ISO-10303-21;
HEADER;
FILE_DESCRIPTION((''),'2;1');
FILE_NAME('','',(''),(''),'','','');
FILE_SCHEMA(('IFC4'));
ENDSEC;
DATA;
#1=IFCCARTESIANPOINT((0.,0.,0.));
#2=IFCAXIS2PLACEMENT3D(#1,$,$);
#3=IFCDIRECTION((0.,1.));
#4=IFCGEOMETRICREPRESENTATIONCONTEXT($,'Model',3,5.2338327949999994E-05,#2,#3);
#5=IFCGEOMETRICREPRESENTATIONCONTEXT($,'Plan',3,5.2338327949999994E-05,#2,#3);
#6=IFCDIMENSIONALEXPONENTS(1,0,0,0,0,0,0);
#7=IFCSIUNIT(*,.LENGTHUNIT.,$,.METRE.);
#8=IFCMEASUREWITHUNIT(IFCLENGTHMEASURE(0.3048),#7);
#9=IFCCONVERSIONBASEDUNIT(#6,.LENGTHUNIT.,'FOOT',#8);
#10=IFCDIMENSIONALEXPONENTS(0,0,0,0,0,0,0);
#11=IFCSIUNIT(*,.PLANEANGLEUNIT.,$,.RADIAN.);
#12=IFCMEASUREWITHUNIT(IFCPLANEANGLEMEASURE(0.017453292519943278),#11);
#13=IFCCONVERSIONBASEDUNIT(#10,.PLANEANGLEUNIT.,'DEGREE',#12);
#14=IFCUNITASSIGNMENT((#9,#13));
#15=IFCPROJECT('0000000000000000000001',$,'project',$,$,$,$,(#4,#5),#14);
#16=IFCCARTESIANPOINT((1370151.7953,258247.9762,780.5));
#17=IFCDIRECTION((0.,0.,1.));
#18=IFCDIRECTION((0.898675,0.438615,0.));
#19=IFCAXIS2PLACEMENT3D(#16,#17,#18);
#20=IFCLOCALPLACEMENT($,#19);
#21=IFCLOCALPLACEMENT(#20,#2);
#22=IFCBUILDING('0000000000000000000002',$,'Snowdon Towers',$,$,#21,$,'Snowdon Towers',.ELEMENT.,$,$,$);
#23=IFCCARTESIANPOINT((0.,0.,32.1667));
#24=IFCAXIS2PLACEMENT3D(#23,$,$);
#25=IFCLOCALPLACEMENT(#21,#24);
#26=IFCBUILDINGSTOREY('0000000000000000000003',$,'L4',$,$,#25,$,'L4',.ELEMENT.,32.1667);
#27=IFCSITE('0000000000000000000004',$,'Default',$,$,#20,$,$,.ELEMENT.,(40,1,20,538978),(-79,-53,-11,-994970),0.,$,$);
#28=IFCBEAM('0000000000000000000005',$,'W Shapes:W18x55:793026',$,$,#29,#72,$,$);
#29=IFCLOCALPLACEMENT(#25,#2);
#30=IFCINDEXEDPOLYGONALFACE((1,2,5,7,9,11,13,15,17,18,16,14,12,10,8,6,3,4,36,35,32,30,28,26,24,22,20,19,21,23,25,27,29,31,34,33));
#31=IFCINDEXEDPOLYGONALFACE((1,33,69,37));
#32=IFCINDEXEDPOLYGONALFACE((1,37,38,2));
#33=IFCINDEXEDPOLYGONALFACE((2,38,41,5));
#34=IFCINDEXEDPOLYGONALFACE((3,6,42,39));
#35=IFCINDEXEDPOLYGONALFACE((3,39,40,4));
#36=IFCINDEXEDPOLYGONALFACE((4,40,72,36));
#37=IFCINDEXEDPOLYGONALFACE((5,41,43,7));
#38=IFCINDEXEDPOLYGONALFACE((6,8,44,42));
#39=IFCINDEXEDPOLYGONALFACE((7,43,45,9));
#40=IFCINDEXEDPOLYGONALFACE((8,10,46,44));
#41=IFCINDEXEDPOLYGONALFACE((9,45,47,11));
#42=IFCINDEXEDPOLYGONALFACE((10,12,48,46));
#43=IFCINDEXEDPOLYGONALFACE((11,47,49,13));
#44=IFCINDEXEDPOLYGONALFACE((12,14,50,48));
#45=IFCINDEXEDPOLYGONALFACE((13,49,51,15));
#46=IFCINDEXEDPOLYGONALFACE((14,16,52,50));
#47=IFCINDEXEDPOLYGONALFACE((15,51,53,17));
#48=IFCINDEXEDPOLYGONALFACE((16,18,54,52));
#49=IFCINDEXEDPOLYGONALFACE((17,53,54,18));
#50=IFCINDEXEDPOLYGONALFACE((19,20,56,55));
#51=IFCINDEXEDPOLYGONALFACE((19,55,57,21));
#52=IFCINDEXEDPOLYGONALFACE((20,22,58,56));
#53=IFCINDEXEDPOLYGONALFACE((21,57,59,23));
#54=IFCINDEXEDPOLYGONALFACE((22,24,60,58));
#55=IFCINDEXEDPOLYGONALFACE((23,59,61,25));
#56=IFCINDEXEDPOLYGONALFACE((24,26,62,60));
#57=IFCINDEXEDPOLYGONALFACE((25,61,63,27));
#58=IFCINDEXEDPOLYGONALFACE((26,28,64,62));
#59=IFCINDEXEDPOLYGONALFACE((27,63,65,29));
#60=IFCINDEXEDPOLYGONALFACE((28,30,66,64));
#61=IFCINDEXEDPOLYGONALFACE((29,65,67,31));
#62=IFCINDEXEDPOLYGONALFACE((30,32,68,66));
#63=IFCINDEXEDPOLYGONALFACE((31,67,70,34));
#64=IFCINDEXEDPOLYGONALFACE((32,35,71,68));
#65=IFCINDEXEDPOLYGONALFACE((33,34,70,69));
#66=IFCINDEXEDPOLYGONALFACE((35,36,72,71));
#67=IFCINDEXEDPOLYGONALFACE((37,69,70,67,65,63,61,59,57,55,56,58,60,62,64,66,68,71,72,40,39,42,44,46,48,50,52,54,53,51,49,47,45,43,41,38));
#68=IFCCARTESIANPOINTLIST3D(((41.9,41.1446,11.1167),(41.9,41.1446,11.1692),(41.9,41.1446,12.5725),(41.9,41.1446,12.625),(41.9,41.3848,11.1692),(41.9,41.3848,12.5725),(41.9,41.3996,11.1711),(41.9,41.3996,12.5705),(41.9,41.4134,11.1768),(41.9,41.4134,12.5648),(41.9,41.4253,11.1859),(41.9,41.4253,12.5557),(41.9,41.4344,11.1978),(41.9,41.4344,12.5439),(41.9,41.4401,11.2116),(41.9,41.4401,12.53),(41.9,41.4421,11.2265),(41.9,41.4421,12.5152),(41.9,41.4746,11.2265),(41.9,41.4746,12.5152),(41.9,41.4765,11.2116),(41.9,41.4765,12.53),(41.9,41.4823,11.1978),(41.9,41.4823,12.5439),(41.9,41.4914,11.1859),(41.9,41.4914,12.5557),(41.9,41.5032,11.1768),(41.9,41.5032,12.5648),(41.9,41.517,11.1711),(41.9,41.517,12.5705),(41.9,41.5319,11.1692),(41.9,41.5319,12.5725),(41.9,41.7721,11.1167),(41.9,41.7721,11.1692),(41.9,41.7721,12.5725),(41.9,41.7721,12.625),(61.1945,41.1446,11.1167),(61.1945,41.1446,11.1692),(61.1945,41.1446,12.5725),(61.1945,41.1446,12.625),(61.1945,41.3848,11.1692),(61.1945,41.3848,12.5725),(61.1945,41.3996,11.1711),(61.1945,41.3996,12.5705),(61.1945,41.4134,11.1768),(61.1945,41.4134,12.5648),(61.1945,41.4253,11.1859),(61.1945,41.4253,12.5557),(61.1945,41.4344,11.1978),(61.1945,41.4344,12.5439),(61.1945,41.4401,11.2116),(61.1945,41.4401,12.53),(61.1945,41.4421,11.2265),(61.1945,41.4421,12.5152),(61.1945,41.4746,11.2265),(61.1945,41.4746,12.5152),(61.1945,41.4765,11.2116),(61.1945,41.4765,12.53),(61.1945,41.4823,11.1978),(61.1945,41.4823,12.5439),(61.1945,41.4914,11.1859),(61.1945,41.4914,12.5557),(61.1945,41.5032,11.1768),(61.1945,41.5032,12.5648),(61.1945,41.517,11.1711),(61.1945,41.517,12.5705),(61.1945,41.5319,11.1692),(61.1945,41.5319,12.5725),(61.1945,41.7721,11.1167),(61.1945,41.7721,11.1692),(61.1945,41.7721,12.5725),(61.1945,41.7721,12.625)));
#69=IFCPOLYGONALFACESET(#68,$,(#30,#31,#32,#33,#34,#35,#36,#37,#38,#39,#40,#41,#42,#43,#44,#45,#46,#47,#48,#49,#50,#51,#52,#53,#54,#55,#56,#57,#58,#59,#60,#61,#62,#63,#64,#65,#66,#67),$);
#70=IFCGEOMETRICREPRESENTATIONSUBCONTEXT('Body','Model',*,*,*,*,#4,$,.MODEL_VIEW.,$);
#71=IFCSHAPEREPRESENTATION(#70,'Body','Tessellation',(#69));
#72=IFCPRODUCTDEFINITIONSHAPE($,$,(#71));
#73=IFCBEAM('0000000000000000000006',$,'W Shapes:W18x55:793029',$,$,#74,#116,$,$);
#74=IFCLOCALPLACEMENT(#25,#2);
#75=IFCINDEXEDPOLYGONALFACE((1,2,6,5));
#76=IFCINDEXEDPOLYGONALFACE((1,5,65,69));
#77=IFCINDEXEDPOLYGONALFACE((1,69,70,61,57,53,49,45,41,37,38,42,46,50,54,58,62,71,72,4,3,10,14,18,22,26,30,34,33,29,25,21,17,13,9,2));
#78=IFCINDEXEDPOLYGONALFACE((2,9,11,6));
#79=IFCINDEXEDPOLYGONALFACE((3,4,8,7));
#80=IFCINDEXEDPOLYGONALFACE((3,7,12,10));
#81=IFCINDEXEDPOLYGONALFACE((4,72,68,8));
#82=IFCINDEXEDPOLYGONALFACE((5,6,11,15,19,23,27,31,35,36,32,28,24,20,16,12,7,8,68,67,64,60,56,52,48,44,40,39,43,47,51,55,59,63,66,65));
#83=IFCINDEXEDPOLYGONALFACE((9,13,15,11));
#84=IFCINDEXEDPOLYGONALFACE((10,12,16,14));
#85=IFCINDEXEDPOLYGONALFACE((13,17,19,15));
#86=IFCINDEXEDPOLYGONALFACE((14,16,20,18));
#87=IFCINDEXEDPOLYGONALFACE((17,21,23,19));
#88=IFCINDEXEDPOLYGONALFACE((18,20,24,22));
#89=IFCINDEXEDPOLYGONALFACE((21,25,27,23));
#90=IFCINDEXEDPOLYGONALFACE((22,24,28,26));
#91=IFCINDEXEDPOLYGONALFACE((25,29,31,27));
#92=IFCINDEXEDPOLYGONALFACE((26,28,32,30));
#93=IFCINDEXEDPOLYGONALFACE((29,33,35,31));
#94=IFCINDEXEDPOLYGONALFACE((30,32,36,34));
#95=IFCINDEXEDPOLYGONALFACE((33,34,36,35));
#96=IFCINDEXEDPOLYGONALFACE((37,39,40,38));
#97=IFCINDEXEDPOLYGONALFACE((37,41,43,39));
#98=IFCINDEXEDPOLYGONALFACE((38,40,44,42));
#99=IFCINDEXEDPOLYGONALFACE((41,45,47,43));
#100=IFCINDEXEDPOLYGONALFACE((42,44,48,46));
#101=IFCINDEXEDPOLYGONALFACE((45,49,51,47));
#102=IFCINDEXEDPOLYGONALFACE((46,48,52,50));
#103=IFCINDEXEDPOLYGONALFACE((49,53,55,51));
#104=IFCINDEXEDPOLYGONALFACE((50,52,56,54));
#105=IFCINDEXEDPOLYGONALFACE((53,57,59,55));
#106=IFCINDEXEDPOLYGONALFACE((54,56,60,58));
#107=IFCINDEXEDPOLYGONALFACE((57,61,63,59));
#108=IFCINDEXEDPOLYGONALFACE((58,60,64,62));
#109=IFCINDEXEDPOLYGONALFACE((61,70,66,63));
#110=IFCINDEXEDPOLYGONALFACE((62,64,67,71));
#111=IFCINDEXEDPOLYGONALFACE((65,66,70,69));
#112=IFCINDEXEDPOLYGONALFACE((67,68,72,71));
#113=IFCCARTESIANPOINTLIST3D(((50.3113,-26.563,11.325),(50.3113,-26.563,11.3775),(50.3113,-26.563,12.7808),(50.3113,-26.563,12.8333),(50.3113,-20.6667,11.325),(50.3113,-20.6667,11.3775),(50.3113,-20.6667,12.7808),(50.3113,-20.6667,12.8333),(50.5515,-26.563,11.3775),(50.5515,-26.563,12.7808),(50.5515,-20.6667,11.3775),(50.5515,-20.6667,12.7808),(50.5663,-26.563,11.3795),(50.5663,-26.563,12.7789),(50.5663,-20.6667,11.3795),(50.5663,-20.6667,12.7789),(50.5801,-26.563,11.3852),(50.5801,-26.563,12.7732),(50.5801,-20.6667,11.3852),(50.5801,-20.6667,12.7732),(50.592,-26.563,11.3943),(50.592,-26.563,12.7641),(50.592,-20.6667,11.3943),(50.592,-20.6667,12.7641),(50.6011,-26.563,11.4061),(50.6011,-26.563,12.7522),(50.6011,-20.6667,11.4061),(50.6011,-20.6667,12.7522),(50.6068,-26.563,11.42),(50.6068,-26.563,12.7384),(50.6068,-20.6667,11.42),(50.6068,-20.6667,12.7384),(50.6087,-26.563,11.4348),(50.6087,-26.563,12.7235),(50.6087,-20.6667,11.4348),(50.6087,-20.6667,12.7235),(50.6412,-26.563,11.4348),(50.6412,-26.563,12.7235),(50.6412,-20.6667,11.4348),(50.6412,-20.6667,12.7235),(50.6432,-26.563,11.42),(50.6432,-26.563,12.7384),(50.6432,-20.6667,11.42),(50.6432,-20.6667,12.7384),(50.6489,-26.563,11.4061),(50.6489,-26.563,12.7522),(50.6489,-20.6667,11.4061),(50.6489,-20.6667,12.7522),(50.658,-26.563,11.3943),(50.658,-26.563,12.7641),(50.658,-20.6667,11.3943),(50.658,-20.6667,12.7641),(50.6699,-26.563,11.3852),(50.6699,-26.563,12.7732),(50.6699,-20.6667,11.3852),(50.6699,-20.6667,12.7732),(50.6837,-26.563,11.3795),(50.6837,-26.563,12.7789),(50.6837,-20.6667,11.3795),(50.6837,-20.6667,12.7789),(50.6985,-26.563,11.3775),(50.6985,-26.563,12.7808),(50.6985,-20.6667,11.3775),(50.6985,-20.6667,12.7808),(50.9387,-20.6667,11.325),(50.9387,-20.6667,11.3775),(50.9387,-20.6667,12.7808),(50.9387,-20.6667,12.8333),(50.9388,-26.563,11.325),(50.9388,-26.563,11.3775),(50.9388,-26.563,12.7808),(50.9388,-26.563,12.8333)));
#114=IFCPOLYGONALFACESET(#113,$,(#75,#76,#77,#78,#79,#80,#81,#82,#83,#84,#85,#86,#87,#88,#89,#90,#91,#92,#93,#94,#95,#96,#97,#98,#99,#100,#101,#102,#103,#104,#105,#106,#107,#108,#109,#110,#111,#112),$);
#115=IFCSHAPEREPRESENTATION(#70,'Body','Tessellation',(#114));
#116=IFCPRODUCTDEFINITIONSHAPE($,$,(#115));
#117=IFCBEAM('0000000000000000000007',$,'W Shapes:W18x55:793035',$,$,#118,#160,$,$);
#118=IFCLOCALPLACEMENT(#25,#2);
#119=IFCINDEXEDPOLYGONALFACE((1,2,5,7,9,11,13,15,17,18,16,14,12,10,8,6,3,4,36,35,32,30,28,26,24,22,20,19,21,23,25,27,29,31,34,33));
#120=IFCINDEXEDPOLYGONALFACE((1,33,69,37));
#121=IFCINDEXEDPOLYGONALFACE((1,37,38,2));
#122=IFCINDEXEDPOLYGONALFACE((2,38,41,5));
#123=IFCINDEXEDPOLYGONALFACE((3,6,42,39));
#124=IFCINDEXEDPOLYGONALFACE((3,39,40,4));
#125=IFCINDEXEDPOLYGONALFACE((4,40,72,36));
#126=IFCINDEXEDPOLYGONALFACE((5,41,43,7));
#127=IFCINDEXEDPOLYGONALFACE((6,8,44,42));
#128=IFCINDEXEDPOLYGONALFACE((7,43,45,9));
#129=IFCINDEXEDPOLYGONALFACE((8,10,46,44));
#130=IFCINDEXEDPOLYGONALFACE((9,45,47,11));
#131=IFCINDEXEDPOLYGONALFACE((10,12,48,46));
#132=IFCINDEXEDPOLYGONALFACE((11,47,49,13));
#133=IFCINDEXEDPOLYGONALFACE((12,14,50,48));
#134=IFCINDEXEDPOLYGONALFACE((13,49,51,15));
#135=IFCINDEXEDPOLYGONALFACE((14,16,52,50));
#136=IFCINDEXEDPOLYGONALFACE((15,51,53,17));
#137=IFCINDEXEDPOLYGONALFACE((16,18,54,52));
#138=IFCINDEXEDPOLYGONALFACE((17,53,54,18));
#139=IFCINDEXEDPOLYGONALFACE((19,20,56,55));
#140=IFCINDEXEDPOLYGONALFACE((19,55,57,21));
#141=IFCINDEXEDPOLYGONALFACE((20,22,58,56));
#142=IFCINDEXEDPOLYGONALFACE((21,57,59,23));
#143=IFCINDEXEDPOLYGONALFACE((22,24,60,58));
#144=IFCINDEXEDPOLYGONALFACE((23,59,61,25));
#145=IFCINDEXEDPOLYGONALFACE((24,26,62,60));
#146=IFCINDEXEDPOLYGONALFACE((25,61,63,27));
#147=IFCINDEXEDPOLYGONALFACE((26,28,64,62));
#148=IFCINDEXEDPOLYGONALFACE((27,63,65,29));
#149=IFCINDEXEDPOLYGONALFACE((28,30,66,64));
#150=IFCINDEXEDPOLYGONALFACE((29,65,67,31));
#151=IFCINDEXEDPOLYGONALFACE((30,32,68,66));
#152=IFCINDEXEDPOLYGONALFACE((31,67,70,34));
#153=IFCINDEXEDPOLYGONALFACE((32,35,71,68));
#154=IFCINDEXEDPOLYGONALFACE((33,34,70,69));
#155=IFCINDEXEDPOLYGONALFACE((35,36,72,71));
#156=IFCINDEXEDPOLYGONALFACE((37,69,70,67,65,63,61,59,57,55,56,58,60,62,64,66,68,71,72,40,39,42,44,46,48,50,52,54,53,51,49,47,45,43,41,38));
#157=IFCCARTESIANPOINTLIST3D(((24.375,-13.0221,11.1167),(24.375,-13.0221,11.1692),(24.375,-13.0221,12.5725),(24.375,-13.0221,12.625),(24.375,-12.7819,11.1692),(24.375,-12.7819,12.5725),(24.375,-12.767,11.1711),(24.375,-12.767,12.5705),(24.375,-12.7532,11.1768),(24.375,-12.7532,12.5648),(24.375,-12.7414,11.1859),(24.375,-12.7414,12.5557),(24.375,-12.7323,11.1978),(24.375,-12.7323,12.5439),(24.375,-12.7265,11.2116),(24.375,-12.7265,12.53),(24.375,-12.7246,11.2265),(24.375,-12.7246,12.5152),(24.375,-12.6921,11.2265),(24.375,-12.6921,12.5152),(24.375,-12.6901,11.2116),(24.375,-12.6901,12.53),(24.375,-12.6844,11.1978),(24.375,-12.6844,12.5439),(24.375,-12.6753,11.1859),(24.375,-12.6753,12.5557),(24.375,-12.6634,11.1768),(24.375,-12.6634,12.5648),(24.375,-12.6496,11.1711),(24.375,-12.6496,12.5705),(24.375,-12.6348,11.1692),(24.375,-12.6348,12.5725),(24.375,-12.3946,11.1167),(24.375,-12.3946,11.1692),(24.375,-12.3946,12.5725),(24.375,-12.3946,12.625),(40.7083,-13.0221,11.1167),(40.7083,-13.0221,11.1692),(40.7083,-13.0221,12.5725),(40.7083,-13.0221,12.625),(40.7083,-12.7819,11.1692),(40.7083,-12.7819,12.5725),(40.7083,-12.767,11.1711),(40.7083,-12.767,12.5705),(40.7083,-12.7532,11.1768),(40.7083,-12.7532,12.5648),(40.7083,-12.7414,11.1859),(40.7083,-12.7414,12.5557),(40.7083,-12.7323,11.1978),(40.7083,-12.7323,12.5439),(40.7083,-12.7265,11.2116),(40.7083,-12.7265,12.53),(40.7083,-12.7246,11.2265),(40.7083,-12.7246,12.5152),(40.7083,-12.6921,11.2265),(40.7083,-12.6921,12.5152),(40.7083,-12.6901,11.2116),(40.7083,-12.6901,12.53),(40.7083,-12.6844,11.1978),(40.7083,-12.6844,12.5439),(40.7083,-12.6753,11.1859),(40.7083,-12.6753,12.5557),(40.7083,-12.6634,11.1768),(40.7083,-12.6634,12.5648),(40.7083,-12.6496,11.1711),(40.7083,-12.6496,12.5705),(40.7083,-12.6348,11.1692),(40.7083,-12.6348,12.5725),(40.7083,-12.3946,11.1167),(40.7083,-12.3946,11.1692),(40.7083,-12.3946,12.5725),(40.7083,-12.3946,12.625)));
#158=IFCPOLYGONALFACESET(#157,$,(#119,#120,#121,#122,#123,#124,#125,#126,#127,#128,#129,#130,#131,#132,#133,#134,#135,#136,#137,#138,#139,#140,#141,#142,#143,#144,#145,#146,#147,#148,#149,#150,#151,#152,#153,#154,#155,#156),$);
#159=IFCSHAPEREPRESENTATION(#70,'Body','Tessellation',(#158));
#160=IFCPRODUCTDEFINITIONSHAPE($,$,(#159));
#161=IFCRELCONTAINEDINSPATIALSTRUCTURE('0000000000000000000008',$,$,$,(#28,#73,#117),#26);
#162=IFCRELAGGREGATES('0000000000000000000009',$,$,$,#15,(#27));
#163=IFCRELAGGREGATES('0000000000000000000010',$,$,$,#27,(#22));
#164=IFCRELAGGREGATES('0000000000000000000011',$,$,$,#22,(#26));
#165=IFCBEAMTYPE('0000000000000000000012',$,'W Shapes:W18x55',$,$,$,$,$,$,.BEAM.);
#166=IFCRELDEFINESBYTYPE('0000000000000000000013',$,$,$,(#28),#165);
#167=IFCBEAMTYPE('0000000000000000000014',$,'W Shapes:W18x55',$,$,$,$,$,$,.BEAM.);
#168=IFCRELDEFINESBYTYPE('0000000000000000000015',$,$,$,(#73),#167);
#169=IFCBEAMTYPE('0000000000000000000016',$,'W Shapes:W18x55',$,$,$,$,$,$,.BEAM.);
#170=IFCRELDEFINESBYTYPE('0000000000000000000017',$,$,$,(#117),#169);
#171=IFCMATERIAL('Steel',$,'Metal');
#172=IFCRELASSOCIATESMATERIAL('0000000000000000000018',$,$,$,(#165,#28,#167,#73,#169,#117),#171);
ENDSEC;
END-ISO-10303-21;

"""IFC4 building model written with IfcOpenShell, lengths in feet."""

from ifc_helpers import new_model, entity, si_unit, converted_unit, direction, frame, origin, place, context, subcontext, project, spatial, line, arc, indexed_curve, outline, extrude, source, transform, mapped, material, type_object, type_shapes, element, save


model = new_model("IFC4")

# Units and contexts
model_context = context("Model", 3, precision=5.2338327949999994e-05, world=origin(), true_north=direction((0.0, 1.0)))
plan_context = context("Plan", 3, precision=5.2338327949999994e-05, world=origin(), true_north=direction((0.0, 1.0)))
body_context = subcontext(model_context, "Body", "Model", "MODEL_VIEW")
ifc_project = project(units=[converted_unit("LENGTHUNIT", "FOOT", entity("IfcLengthMeasure", 0.3048), si_unit("LENGTHUNIT", "METRE"), dimensions=[1, 0, 0, 0, 0, 0, 0]), converted_unit("PLANEANGLEUNIT", "DEGREE", entity("IfcPlaneAngleMeasure", 0.017453292519943278), si_unit("PLANEANGLEUNIT", "RADIAN"), dimensions=[0, 0, 0, 0, 0, 0, 0])], contexts=[model_context, plan_context])

# Site, building, storey
site_placement = place(None, frame((1370151.7953, 258247.9762, 780.5), z_axis=(0.0, 0.0, 1.0), x_axis=(0.898675, 0.438615, 0.0)))
site = spatial("IfcSite", under=ifc_project, at=site_placement, Name="Default", CompositionType="ELEMENT", RefLatitude=(40, 1, 20, 538978), RefLongitude=(-79, -53, -11, -994970), RefElevation=0.0)
building_placement = place(site_placement, origin())
building = spatial("IfcBuilding", under=site, at=building_placement, Name="Snowdon Towers", LongName="Snowdon Towers", CompositionType="ELEMENT")
storey_placement = place(building_placement, frame((0.0, 0.0, 32.1667)))
storey = spatial("IfcBuildingStorey", under=building, at=storey_placement, Name="L4", LongName="L4", CompositionType="ELEMENT", Elevation=32.1667)

# Beams
ifc_material = material(Name="Steel", Category="Metal")
beam_type_1 = type_object("IfcBeamType", Name="W Shapes:W18x55", PredefinedType="BEAM", material=ifc_material)
shared_shape_1 = source(origin(), body_context, "Body", "SweptSolid", [
    extrude(outline(indexed_curve([(-0.7542, -0.3138), (-0.7017, -0.3138), (-0.7017, -0.0735), (-0.6849, -0.033), (-0.6444, -0.0162), (0.6444, -0.0162), (0.6849, -0.033), (0.7017, -0.0735), (0.7017, -0.3138), (0.7542, -0.3138), (0.7542, 0.3138), (0.7017, 0.3138), (0.7017, 0.0735), (0.6849, 0.033), (0.6444, 0.0163), (-0.6444, 0.0163), (-0.6849, 0.033), (-0.7017, 0.0735), (-0.7017, 0.3137), (-0.7542, 0.3137)], segments=[line(1, 2, 3), arc(3, 4, 5), line(5, 6), arc(6, 7, 8), line(8, 9, 10, 11, 12, 13), arc(13, 14, 15), line(15, 16), arc(16, 17, 18), line(18, 19, 20, 1)], self_intersect=False)), frame((-9.9242, 0.0, 0.0), z_axis=(1.0, 0.0, 0.0), x_axis=(0.0, 0.0, -1.0)), (0.0, 0.0, 1.0), 19.2945),
])
type_shapes(beam_type_1, [shared_shape_1])
beam_1_placement = place(storey_placement, frame((51.8242, 41.4583, 11.8708)))
element("IfcBeam", 1, at=beam_1_placement, inside=storey, type_object=beam_type_1, material=ifc_material, Name="W Shapes:W18x55:793026", context=body_context, shape_type="MappedRepresentation", body=[
    mapped(shared_shape_1, transform((0.0, 0.0, 0.0), scale=1.0)),
])
beam_type_2 = type_object("IfcBeamType", Name="W Shapes:W18x55", PredefinedType="BEAM", material=ifc_material)
shared_shape_2 = source(origin(), body_context, "Body", "SweptSolid", [
    extrude(outline(indexed_curve([(-0.7542, -0.3138), (-0.7017, -0.3138), (-0.7017, -0.0735), (-0.6849, -0.033), (-0.6444, -0.0162), (0.6444, -0.0162), (0.6849, -0.033), (0.7017, -0.0735), (0.7017, -0.3138), (0.7542, -0.3138), (0.7542, 0.3138), (0.7017, 0.3138), (0.7017, 0.0735), (0.6849, 0.033), (0.6444, 0.0163), (-0.6444, 0.0163), (-0.6849, 0.033), (-0.7017, 0.0735), (-0.7017, 0.3137), (-0.7542, 0.3137)], segments=[line(1, 2, 3), arc(3, 4, 5), line(5, 6), arc(6, 7, 8), line(8, 9, 10, 11, 12, 13), arc(13, 14, 15), line(15, 16), arc(16, 17, 18), line(18, 19, 20, 1)], self_intersect=False)), frame((-2.8655, 0.0, 0.0), z_axis=(1.0, 0.0, 0.0), x_axis=(0.0, 0.0, -1.0)), (0.0, 0.0, 1.0), 5.8964),
])
type_shapes(beam_type_2, [shared_shape_2])
beam_2_placement = place(storey_placement, frame((50.625, -23.5321, 12.0792), z_axis=(0.0, 0.0, 1.0), x_axis=(0.0, -1.0, 0.0)))
element("IfcBeam", 2, at=beam_2_placement, inside=storey, type_object=beam_type_2, material=ifc_material, Name="W Shapes:W18x55:793029", context=body_context, shape_type="MappedRepresentation", body=[
    mapped(shared_shape_2, transform((0.0, 0.0, 0.0), scale=1.0)),
])
beam_type_3 = type_object("IfcBeamType", Name="W Shapes:W18x55", PredefinedType="BEAM", material=ifc_material)
shared_shape_3 = source(origin(), body_context, "Body", "SweptSolid", [
    extrude(outline(indexed_curve([(-0.7542, -0.3138), (-0.7017, -0.3138), (-0.7017, -0.0735), (-0.6849, -0.033), (-0.6444, -0.0162), (0.6444, -0.0162), (0.6849, -0.033), (0.7017, -0.0735), (0.7017, -0.3138), (0.7542, -0.3138), (0.7542, 0.3138), (0.7017, 0.3138), (0.7017, 0.0735), (0.6849, 0.033), (0.6444, 0.0163), (-0.6444, 0.0163), (-0.6849, 0.033), (-0.7017, 0.0735), (-0.7017, 0.3137), (-0.7542, 0.3137)], segments=[line(1, 2, 3), arc(3, 4, 5), line(5, 6), arc(6, 7, 8), line(8, 9, 10, 11, 12, 13), arc(13, 14, 15), line(15, 16), arc(16, 17, 18), line(18, 19, 20, 1)], self_intersect=False)), frame((-8.2083, 0.0, 0.0), z_axis=(1.0, 0.0, 0.0), x_axis=(0.0, 0.0, -1.0)), (0.0, 0.0, 1.0), 16.3333),
])
type_shapes(beam_type_3, [shared_shape_3])
beam_3_placement = place(storey_placement, frame((32.5833, -12.7083, 11.8708)))
element("IfcBeam", 3, at=beam_3_placement, inside=storey, type_object=beam_type_3, material=ifc_material, Name="W Shapes:W18x55:793035", context=body_context, shape_type="MappedRepresentation", body=[
    mapped(shared_shape_3, transform((0.0, 0.0, 0.0), scale=1.0)),
])

save(model, "model.ifc")
